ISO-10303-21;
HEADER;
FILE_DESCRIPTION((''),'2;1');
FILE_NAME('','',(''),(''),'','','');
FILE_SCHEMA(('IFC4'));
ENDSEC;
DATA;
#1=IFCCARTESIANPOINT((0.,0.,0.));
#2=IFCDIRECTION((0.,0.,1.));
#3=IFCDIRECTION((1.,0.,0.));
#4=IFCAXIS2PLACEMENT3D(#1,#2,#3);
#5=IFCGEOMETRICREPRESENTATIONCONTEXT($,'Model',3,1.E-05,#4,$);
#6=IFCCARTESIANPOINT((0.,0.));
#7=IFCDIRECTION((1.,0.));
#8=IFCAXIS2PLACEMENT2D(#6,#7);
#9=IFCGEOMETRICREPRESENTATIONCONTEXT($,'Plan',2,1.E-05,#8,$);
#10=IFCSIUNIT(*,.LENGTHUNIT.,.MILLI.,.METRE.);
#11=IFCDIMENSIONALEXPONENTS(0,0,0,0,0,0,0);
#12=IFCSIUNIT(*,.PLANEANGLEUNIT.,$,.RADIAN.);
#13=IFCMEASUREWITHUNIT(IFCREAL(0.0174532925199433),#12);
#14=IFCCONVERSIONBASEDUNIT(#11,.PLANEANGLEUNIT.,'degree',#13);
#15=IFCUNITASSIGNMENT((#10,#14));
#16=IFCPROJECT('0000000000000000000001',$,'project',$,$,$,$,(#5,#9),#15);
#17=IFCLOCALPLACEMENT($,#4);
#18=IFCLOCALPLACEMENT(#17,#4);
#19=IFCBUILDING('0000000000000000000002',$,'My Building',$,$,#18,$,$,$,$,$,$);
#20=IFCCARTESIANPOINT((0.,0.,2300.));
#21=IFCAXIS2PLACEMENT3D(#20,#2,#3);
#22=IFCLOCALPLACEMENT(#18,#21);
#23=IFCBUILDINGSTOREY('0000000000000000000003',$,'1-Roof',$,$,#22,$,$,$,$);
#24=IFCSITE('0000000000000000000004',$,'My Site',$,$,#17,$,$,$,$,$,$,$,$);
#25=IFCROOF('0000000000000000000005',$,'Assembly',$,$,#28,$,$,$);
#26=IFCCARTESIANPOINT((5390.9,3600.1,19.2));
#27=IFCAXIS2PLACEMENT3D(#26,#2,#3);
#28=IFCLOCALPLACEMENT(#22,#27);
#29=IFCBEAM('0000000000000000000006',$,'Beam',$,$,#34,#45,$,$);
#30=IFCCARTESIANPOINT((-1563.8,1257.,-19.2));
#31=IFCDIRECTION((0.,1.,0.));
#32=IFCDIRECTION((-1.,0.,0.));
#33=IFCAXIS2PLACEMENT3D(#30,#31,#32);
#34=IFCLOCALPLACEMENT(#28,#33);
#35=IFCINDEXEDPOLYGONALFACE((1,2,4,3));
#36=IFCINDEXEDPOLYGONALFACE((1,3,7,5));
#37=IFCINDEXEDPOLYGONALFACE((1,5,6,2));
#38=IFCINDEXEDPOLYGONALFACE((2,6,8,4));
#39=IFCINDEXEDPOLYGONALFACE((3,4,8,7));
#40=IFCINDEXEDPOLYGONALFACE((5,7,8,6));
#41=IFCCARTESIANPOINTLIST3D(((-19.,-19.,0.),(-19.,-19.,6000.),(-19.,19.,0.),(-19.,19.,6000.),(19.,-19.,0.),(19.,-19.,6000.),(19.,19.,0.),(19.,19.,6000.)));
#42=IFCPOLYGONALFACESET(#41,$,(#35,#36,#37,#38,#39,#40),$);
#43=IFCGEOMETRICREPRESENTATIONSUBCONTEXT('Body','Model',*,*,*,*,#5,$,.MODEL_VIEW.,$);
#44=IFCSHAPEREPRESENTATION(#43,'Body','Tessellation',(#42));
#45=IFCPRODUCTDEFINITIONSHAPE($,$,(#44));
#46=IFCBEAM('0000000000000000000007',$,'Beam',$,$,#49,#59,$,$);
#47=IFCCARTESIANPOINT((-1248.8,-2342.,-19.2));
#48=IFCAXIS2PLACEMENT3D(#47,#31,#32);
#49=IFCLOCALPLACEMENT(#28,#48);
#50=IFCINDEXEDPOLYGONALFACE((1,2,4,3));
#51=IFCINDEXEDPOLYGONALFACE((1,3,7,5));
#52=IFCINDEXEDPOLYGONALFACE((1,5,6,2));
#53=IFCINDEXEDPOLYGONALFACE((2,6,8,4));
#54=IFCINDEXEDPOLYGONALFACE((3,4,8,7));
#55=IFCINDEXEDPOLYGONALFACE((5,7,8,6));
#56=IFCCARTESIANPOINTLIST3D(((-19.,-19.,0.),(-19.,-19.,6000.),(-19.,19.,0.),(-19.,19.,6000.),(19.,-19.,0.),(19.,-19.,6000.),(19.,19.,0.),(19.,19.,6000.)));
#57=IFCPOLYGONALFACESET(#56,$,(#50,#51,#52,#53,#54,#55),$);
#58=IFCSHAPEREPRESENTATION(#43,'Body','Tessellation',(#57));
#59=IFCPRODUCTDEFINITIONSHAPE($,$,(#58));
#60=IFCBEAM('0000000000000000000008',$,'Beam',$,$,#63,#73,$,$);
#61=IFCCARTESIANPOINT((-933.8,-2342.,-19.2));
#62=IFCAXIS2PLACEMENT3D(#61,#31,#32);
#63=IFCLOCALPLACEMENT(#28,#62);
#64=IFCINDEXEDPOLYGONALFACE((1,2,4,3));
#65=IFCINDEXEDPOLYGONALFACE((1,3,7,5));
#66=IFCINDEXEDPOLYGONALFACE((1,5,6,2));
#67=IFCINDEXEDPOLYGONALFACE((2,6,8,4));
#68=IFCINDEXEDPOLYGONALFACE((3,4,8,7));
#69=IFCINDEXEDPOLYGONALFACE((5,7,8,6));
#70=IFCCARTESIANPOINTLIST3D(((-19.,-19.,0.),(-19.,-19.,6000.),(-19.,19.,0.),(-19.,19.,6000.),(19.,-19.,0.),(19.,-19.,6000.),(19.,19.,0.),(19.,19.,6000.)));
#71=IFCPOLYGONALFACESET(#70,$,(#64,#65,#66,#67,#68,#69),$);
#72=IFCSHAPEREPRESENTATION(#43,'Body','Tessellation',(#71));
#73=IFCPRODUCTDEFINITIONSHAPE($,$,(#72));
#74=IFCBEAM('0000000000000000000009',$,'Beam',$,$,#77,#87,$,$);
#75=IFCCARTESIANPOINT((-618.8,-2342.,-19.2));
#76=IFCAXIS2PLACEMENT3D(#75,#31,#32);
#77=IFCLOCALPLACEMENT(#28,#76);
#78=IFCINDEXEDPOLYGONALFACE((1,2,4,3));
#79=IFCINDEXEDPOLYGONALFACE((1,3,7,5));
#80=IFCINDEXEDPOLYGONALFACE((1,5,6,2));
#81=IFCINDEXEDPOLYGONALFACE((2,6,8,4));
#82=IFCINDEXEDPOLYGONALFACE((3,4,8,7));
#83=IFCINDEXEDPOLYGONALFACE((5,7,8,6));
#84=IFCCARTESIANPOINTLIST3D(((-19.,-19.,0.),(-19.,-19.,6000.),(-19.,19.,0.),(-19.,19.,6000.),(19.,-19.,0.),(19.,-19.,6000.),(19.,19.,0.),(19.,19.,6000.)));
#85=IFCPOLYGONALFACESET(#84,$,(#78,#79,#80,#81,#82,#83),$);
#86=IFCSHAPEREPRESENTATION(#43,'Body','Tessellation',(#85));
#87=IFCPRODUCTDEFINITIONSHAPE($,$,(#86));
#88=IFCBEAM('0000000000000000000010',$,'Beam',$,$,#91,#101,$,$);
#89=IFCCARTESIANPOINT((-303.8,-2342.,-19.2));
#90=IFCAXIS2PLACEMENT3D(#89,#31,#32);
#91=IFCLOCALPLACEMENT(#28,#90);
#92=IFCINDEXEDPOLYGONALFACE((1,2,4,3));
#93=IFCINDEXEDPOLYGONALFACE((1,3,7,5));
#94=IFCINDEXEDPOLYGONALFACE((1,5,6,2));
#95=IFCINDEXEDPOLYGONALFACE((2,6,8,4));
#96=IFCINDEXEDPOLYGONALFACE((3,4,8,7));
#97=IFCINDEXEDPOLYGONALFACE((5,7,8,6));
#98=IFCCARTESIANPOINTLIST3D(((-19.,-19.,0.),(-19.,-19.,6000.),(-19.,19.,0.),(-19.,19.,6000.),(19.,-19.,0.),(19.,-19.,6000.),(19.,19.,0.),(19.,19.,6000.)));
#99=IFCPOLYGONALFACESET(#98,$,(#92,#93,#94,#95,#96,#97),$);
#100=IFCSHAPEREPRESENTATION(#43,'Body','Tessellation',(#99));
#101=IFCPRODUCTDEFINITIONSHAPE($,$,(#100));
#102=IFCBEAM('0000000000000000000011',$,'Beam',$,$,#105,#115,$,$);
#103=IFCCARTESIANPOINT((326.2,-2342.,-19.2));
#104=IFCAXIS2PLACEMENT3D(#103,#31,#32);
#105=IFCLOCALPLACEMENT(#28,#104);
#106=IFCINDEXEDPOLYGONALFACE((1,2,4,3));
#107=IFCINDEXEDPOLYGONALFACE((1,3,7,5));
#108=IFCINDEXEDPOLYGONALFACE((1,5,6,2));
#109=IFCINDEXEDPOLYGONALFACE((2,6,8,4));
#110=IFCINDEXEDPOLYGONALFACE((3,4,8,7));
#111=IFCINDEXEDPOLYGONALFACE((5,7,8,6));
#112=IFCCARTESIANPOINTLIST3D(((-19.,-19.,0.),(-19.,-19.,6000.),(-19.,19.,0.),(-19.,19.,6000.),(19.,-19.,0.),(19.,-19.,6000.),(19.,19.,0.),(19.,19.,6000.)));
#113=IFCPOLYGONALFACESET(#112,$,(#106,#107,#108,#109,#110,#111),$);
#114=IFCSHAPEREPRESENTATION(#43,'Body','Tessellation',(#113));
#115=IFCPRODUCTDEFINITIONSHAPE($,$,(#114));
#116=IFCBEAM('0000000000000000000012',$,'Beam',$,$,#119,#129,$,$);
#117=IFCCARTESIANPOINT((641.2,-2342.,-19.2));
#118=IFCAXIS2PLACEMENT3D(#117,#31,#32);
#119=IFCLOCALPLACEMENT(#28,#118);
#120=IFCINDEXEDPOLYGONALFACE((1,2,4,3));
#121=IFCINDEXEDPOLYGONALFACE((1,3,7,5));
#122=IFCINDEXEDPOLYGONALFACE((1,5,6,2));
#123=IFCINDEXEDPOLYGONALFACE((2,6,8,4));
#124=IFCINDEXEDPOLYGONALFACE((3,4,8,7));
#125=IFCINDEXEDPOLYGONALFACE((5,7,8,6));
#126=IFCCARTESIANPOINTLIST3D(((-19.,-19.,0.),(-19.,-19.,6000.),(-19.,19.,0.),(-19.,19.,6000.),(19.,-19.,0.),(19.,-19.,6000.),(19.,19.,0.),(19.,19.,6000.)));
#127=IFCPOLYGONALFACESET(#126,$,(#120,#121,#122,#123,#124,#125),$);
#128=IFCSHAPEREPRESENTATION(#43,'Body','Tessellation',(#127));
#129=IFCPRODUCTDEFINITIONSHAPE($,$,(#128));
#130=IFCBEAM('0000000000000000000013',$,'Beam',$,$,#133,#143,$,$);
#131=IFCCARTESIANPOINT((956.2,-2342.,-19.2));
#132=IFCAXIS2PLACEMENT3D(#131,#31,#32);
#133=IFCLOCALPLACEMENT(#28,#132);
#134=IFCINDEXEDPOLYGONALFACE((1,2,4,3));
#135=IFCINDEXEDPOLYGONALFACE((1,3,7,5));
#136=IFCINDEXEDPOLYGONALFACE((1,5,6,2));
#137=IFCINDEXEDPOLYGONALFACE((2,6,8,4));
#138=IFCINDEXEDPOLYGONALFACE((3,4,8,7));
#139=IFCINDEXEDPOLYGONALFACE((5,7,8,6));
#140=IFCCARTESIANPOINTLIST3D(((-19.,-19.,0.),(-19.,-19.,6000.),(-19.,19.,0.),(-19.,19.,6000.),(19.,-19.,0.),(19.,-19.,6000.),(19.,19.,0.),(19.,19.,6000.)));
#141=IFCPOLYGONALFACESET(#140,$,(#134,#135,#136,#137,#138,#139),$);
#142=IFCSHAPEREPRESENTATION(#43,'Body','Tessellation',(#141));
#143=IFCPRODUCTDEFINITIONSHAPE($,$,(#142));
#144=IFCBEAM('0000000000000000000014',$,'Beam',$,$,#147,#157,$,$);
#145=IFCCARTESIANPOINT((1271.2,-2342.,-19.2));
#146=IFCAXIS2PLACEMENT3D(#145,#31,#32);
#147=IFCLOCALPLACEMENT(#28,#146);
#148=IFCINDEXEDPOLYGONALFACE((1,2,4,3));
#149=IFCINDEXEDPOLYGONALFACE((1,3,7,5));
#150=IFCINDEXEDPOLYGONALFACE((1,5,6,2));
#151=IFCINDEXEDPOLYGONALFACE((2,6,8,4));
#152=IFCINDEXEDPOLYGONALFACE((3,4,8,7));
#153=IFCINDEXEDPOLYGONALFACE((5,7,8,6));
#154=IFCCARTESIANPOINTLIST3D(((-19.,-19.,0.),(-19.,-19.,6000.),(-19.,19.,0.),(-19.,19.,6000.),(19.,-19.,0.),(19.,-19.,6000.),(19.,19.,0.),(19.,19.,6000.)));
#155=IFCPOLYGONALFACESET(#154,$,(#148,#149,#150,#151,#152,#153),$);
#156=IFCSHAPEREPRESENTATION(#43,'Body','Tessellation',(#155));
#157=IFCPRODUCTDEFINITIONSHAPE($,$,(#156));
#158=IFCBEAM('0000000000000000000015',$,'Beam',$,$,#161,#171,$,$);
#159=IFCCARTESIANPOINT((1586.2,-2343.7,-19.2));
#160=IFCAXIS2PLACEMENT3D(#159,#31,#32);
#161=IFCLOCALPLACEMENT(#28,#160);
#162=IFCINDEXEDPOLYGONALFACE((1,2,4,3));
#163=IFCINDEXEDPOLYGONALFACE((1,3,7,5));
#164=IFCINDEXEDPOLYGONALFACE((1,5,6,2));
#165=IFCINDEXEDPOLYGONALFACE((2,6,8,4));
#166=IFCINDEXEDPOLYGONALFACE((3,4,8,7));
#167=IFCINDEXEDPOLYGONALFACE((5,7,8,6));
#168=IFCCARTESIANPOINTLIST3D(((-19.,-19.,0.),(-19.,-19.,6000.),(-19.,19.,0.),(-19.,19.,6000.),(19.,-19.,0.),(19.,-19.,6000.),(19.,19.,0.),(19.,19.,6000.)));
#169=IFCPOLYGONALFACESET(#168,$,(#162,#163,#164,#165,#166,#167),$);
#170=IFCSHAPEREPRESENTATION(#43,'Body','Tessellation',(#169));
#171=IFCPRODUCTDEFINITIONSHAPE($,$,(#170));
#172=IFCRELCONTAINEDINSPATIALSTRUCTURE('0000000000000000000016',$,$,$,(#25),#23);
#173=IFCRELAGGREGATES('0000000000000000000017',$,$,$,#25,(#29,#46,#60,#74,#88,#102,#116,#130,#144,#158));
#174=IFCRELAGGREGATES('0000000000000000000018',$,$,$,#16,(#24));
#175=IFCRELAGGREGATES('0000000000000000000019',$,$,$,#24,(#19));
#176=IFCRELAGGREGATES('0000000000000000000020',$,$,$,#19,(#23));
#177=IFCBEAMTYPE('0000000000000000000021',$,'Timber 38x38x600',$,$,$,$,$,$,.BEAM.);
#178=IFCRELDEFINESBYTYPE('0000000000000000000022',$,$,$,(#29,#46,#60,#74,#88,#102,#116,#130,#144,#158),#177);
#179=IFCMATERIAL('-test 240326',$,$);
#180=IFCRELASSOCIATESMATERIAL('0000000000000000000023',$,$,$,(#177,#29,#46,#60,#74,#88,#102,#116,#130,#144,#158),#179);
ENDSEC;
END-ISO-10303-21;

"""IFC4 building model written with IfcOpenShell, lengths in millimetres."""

from ifc_helpers import new_model, entity, si_unit, converted_unit, frame, origin_with_axes, origin_2d_with_axis, place, context, subcontext, project, spatial, rectangle, extrude, material, material_profile, profile_set, profile_usage, type_object, element, aggregate, save


model = new_model("IFC4")

# Units and contexts
model_context = context("Model", 3, precision=1e-05, world=origin_with_axes())
plan_context = context("Plan", 2, precision=1e-05, world=origin_2d_with_axis())
body_context = subcontext(model_context, "Body", "Model", "MODEL_VIEW")
ifc_project = project(units=[si_unit("LENGTHUNIT", "METRE", prefix="MILLI"), converted_unit("PLANEANGLEUNIT", "degree", entity("IfcReal", 0.0174532925199433), si_unit("PLANEANGLEUNIT", "RADIAN"), dimensions=[0, 0, 0, 0, 0, 0, 0])], contexts=[model_context, plan_context])

# Site, building, storey
site_placement = place(None, origin_with_axes())
site = spatial("IfcSite", under=ifc_project, at=site_placement, Name="My Site")
building_placement = place(site_placement, origin_with_axes())
building = spatial("IfcBuilding", under=site, at=building_placement, Name="My Building")
storey_placement = place(building_placement, frame((0.0, 0.0, 2300.0), z_axis=(0.0, 0.0, 1.0), x_axis=(1.0, 0.0, 0.0)))
storey = spatial("IfcBuildingStorey", under=building, at=storey_placement, Name="1-Roof")

# Roof, beams
roof_placement = place(storey_placement, frame((5390.9, 3600.1, 19.2), z_axis=(0.0, 0.0, 1.0), x_axis=(1.0, 0.0, 0.0)))
roof = element("IfcRoof", 1, at=roof_placement, inside=storey, Name="Assembly")
ifc_material_1 = material(Name="-test 240326")
ifc_material_profile_1 = material_profile(ifc_material_1, rectangle(XDim=38.0, YDim=38.0))
ifc_profile_set_1 = profile_set([ifc_material_profile_1])
beam_type_1 = type_object("IfcBeamType", Name="Timber 38x38x600", PredefinedType="BEAM", material=ifc_profile_set_1)
ifc_profile_usage_1 = profile_usage(ifc_profile_set_1, cardinal=5)
beam_1_placement = place(roof_placement, frame((-1563.8, 1257.0, -19.2), z_axis=(0.0, 1.0, 0.0), x_axis=(-1.0, 0.0, 0.0)))
beam_1 = element("IfcBeam", 2, at=beam_1_placement, type_object=beam_type_1, material=ifc_profile_usage_1, Name="Beam", context=body_context, shape_type="SweptSolid", body=[
    extrude(rectangle(XDim=38.0, YDim=38.0), origin_with_axes(), (0.0, 0.0, 1.0), 6000.0),
])
ifc_profile_usage_2 = profile_usage(ifc_profile_set_1, cardinal=5)
beam_2_placement = place(roof_placement, frame((-1248.8, -2342.0, -19.2), z_axis=(0.0, 1.0, 0.0), x_axis=(-1.0, 0.0, 0.0)))
beam_2 = element("IfcBeam", 3, at=beam_2_placement, type_object=beam_type_1, material=ifc_profile_usage_2, Name="Beam", context=body_context, shape_type="SweptSolid", body=[
    extrude(rectangle(XDim=38.0, YDim=38.0), origin_with_axes(), (0.0, 0.0, 1.0), 6000.0),
])
ifc_profile_usage_3 = profile_usage(ifc_profile_set_1, cardinal=5)
beam_3_placement = place(roof_placement, frame((-933.8, -2342.0, -19.2), z_axis=(0.0, 1.0, 0.0), x_axis=(-1.0, 0.0, 0.0)))
beam_3 = element("IfcBeam", 4, at=beam_3_placement, type_object=beam_type_1, material=ifc_profile_usage_3, Name="Beam", context=body_context, shape_type="SweptSolid", body=[
    extrude(rectangle(XDim=38.0, YDim=38.0), origin_with_axes(), (0.0, 0.0, 1.0), 6000.0),
])
ifc_profile_usage_4 = profile_usage(ifc_profile_set_1, cardinal=5)
beam_4_placement = place(roof_placement, frame((-618.8, -2342.0, -19.2), z_axis=(0.0, 1.0, 0.0), x_axis=(-1.0, 0.0, 0.0)))
beam_4 = element("IfcBeam", 5, at=beam_4_placement, type_object=beam_type_1, material=ifc_profile_usage_4, Name="Beam", context=body_context, shape_type="SweptSolid", body=[
    extrude(rectangle(XDim=38.0, YDim=38.0), origin_with_axes(), (0.0, 0.0, 1.0), 6000.0),
])
ifc_profile_usage_5 = profile_usage(ifc_profile_set_1, cardinal=5)
beam_5_placement = place(roof_placement, frame((-303.8, -2342.0, -19.2), z_axis=(0.0, 1.0, 0.0), x_axis=(-1.0, 0.0, 0.0)))
beam_5 = element("IfcBeam", 6, at=beam_5_placement, type_object=beam_type_1, material=ifc_profile_usage_5, Name="Beam", context=body_context, shape_type="SweptSolid", body=[
    extrude(rectangle(XDim=38.0, YDim=38.0), origin_with_axes(), (0.0, 0.0, 1.0), 6000.0),
])
ifc_profile_usage_6 = profile_usage(ifc_profile_set_1, cardinal=5)
beam_6_placement = place(roof_placement, frame((326.2, -2342.0, -19.2), z_axis=(0.0, 1.0, 0.0), x_axis=(-1.0, 0.0, 0.0)))
beam_6 = element("IfcBeam", 7, at=beam_6_placement, type_object=beam_type_1, material=ifc_profile_usage_6, Name="Beam", context=body_context, shape_type="SweptSolid", body=[
    extrude(rectangle(XDim=38.0, YDim=38.0), origin_with_axes(), (0.0, 0.0, 1.0), 6000.0),
])
ifc_profile_usage_7 = profile_usage(ifc_profile_set_1, cardinal=5)
beam_7_placement = place(roof_placement, frame((641.2, -2342.0, -19.2), z_axis=(0.0, 1.0, 0.0), x_axis=(-1.0, 0.0, 0.0)))
beam_7 = element("IfcBeam", 8, at=beam_7_placement, type_object=beam_type_1, material=ifc_profile_usage_7, Name="Beam", context=body_context, shape_type="SweptSolid", body=[
    extrude(rectangle(XDim=38.0, YDim=38.0), origin_with_axes(), (0.0, 0.0, 1.0), 6000.0),
])
ifc_profile_usage_8 = profile_usage(ifc_profile_set_1, cardinal=5)
beam_8_placement = place(roof_placement, frame((956.2, -2342.0, -19.2), z_axis=(0.0, 1.0, 0.0), x_axis=(-1.0, 0.0, 0.0)))
beam_8 = element("IfcBeam", 9, at=beam_8_placement, type_object=beam_type_1, material=ifc_profile_usage_8, Name="Beam", context=body_context, shape_type="SweptSolid", body=[
    extrude(rectangle(XDim=38.0, YDim=38.0), origin_with_axes(), (0.0, 0.0, 1.0), 6000.0),
])
ifc_profile_usage_9 = profile_usage(ifc_profile_set_1, cardinal=5)
beam_9_placement = place(roof_placement, frame((1271.2, -2342.0, -19.2), z_axis=(0.0, 1.0, 0.0), x_axis=(-1.0, 0.0, 0.0)))
beam_9 = element("IfcBeam", 10, at=beam_9_placement, type_object=beam_type_1, material=ifc_profile_usage_9, Name="Beam", context=body_context, shape_type="SweptSolid", body=[
    extrude(rectangle(XDim=38.0, YDim=38.0), origin_with_axes(), (0.0, 0.0, 1.0), 6000.0),
])
ifc_profile_usage_10 = profile_usage(ifc_profile_set_1, cardinal=5)
beam_10_placement = place(roof_placement, frame((1586.2, -2343.7, -19.2), z_axis=(0.0, 1.0, 0.0), x_axis=(-1.0, 0.0, 0.0)))
beam_10 = element("IfcBeam", 11, at=beam_10_placement, type_object=beam_type_1, material=ifc_profile_usage_10, Name="Beam", context=body_context, shape_type="SweptSolid", body=[
    extrude(rectangle(XDim=38.0, YDim=38.0), origin_with_axes(), (0.0, 0.0, 1.0), 6000.0),
])
aggregate(roof, [beam_1, beam_2, beam_3, beam_4, beam_5, beam_6, beam_7, beam_8, beam_9, beam_10])

save(model, "model.ifc")
